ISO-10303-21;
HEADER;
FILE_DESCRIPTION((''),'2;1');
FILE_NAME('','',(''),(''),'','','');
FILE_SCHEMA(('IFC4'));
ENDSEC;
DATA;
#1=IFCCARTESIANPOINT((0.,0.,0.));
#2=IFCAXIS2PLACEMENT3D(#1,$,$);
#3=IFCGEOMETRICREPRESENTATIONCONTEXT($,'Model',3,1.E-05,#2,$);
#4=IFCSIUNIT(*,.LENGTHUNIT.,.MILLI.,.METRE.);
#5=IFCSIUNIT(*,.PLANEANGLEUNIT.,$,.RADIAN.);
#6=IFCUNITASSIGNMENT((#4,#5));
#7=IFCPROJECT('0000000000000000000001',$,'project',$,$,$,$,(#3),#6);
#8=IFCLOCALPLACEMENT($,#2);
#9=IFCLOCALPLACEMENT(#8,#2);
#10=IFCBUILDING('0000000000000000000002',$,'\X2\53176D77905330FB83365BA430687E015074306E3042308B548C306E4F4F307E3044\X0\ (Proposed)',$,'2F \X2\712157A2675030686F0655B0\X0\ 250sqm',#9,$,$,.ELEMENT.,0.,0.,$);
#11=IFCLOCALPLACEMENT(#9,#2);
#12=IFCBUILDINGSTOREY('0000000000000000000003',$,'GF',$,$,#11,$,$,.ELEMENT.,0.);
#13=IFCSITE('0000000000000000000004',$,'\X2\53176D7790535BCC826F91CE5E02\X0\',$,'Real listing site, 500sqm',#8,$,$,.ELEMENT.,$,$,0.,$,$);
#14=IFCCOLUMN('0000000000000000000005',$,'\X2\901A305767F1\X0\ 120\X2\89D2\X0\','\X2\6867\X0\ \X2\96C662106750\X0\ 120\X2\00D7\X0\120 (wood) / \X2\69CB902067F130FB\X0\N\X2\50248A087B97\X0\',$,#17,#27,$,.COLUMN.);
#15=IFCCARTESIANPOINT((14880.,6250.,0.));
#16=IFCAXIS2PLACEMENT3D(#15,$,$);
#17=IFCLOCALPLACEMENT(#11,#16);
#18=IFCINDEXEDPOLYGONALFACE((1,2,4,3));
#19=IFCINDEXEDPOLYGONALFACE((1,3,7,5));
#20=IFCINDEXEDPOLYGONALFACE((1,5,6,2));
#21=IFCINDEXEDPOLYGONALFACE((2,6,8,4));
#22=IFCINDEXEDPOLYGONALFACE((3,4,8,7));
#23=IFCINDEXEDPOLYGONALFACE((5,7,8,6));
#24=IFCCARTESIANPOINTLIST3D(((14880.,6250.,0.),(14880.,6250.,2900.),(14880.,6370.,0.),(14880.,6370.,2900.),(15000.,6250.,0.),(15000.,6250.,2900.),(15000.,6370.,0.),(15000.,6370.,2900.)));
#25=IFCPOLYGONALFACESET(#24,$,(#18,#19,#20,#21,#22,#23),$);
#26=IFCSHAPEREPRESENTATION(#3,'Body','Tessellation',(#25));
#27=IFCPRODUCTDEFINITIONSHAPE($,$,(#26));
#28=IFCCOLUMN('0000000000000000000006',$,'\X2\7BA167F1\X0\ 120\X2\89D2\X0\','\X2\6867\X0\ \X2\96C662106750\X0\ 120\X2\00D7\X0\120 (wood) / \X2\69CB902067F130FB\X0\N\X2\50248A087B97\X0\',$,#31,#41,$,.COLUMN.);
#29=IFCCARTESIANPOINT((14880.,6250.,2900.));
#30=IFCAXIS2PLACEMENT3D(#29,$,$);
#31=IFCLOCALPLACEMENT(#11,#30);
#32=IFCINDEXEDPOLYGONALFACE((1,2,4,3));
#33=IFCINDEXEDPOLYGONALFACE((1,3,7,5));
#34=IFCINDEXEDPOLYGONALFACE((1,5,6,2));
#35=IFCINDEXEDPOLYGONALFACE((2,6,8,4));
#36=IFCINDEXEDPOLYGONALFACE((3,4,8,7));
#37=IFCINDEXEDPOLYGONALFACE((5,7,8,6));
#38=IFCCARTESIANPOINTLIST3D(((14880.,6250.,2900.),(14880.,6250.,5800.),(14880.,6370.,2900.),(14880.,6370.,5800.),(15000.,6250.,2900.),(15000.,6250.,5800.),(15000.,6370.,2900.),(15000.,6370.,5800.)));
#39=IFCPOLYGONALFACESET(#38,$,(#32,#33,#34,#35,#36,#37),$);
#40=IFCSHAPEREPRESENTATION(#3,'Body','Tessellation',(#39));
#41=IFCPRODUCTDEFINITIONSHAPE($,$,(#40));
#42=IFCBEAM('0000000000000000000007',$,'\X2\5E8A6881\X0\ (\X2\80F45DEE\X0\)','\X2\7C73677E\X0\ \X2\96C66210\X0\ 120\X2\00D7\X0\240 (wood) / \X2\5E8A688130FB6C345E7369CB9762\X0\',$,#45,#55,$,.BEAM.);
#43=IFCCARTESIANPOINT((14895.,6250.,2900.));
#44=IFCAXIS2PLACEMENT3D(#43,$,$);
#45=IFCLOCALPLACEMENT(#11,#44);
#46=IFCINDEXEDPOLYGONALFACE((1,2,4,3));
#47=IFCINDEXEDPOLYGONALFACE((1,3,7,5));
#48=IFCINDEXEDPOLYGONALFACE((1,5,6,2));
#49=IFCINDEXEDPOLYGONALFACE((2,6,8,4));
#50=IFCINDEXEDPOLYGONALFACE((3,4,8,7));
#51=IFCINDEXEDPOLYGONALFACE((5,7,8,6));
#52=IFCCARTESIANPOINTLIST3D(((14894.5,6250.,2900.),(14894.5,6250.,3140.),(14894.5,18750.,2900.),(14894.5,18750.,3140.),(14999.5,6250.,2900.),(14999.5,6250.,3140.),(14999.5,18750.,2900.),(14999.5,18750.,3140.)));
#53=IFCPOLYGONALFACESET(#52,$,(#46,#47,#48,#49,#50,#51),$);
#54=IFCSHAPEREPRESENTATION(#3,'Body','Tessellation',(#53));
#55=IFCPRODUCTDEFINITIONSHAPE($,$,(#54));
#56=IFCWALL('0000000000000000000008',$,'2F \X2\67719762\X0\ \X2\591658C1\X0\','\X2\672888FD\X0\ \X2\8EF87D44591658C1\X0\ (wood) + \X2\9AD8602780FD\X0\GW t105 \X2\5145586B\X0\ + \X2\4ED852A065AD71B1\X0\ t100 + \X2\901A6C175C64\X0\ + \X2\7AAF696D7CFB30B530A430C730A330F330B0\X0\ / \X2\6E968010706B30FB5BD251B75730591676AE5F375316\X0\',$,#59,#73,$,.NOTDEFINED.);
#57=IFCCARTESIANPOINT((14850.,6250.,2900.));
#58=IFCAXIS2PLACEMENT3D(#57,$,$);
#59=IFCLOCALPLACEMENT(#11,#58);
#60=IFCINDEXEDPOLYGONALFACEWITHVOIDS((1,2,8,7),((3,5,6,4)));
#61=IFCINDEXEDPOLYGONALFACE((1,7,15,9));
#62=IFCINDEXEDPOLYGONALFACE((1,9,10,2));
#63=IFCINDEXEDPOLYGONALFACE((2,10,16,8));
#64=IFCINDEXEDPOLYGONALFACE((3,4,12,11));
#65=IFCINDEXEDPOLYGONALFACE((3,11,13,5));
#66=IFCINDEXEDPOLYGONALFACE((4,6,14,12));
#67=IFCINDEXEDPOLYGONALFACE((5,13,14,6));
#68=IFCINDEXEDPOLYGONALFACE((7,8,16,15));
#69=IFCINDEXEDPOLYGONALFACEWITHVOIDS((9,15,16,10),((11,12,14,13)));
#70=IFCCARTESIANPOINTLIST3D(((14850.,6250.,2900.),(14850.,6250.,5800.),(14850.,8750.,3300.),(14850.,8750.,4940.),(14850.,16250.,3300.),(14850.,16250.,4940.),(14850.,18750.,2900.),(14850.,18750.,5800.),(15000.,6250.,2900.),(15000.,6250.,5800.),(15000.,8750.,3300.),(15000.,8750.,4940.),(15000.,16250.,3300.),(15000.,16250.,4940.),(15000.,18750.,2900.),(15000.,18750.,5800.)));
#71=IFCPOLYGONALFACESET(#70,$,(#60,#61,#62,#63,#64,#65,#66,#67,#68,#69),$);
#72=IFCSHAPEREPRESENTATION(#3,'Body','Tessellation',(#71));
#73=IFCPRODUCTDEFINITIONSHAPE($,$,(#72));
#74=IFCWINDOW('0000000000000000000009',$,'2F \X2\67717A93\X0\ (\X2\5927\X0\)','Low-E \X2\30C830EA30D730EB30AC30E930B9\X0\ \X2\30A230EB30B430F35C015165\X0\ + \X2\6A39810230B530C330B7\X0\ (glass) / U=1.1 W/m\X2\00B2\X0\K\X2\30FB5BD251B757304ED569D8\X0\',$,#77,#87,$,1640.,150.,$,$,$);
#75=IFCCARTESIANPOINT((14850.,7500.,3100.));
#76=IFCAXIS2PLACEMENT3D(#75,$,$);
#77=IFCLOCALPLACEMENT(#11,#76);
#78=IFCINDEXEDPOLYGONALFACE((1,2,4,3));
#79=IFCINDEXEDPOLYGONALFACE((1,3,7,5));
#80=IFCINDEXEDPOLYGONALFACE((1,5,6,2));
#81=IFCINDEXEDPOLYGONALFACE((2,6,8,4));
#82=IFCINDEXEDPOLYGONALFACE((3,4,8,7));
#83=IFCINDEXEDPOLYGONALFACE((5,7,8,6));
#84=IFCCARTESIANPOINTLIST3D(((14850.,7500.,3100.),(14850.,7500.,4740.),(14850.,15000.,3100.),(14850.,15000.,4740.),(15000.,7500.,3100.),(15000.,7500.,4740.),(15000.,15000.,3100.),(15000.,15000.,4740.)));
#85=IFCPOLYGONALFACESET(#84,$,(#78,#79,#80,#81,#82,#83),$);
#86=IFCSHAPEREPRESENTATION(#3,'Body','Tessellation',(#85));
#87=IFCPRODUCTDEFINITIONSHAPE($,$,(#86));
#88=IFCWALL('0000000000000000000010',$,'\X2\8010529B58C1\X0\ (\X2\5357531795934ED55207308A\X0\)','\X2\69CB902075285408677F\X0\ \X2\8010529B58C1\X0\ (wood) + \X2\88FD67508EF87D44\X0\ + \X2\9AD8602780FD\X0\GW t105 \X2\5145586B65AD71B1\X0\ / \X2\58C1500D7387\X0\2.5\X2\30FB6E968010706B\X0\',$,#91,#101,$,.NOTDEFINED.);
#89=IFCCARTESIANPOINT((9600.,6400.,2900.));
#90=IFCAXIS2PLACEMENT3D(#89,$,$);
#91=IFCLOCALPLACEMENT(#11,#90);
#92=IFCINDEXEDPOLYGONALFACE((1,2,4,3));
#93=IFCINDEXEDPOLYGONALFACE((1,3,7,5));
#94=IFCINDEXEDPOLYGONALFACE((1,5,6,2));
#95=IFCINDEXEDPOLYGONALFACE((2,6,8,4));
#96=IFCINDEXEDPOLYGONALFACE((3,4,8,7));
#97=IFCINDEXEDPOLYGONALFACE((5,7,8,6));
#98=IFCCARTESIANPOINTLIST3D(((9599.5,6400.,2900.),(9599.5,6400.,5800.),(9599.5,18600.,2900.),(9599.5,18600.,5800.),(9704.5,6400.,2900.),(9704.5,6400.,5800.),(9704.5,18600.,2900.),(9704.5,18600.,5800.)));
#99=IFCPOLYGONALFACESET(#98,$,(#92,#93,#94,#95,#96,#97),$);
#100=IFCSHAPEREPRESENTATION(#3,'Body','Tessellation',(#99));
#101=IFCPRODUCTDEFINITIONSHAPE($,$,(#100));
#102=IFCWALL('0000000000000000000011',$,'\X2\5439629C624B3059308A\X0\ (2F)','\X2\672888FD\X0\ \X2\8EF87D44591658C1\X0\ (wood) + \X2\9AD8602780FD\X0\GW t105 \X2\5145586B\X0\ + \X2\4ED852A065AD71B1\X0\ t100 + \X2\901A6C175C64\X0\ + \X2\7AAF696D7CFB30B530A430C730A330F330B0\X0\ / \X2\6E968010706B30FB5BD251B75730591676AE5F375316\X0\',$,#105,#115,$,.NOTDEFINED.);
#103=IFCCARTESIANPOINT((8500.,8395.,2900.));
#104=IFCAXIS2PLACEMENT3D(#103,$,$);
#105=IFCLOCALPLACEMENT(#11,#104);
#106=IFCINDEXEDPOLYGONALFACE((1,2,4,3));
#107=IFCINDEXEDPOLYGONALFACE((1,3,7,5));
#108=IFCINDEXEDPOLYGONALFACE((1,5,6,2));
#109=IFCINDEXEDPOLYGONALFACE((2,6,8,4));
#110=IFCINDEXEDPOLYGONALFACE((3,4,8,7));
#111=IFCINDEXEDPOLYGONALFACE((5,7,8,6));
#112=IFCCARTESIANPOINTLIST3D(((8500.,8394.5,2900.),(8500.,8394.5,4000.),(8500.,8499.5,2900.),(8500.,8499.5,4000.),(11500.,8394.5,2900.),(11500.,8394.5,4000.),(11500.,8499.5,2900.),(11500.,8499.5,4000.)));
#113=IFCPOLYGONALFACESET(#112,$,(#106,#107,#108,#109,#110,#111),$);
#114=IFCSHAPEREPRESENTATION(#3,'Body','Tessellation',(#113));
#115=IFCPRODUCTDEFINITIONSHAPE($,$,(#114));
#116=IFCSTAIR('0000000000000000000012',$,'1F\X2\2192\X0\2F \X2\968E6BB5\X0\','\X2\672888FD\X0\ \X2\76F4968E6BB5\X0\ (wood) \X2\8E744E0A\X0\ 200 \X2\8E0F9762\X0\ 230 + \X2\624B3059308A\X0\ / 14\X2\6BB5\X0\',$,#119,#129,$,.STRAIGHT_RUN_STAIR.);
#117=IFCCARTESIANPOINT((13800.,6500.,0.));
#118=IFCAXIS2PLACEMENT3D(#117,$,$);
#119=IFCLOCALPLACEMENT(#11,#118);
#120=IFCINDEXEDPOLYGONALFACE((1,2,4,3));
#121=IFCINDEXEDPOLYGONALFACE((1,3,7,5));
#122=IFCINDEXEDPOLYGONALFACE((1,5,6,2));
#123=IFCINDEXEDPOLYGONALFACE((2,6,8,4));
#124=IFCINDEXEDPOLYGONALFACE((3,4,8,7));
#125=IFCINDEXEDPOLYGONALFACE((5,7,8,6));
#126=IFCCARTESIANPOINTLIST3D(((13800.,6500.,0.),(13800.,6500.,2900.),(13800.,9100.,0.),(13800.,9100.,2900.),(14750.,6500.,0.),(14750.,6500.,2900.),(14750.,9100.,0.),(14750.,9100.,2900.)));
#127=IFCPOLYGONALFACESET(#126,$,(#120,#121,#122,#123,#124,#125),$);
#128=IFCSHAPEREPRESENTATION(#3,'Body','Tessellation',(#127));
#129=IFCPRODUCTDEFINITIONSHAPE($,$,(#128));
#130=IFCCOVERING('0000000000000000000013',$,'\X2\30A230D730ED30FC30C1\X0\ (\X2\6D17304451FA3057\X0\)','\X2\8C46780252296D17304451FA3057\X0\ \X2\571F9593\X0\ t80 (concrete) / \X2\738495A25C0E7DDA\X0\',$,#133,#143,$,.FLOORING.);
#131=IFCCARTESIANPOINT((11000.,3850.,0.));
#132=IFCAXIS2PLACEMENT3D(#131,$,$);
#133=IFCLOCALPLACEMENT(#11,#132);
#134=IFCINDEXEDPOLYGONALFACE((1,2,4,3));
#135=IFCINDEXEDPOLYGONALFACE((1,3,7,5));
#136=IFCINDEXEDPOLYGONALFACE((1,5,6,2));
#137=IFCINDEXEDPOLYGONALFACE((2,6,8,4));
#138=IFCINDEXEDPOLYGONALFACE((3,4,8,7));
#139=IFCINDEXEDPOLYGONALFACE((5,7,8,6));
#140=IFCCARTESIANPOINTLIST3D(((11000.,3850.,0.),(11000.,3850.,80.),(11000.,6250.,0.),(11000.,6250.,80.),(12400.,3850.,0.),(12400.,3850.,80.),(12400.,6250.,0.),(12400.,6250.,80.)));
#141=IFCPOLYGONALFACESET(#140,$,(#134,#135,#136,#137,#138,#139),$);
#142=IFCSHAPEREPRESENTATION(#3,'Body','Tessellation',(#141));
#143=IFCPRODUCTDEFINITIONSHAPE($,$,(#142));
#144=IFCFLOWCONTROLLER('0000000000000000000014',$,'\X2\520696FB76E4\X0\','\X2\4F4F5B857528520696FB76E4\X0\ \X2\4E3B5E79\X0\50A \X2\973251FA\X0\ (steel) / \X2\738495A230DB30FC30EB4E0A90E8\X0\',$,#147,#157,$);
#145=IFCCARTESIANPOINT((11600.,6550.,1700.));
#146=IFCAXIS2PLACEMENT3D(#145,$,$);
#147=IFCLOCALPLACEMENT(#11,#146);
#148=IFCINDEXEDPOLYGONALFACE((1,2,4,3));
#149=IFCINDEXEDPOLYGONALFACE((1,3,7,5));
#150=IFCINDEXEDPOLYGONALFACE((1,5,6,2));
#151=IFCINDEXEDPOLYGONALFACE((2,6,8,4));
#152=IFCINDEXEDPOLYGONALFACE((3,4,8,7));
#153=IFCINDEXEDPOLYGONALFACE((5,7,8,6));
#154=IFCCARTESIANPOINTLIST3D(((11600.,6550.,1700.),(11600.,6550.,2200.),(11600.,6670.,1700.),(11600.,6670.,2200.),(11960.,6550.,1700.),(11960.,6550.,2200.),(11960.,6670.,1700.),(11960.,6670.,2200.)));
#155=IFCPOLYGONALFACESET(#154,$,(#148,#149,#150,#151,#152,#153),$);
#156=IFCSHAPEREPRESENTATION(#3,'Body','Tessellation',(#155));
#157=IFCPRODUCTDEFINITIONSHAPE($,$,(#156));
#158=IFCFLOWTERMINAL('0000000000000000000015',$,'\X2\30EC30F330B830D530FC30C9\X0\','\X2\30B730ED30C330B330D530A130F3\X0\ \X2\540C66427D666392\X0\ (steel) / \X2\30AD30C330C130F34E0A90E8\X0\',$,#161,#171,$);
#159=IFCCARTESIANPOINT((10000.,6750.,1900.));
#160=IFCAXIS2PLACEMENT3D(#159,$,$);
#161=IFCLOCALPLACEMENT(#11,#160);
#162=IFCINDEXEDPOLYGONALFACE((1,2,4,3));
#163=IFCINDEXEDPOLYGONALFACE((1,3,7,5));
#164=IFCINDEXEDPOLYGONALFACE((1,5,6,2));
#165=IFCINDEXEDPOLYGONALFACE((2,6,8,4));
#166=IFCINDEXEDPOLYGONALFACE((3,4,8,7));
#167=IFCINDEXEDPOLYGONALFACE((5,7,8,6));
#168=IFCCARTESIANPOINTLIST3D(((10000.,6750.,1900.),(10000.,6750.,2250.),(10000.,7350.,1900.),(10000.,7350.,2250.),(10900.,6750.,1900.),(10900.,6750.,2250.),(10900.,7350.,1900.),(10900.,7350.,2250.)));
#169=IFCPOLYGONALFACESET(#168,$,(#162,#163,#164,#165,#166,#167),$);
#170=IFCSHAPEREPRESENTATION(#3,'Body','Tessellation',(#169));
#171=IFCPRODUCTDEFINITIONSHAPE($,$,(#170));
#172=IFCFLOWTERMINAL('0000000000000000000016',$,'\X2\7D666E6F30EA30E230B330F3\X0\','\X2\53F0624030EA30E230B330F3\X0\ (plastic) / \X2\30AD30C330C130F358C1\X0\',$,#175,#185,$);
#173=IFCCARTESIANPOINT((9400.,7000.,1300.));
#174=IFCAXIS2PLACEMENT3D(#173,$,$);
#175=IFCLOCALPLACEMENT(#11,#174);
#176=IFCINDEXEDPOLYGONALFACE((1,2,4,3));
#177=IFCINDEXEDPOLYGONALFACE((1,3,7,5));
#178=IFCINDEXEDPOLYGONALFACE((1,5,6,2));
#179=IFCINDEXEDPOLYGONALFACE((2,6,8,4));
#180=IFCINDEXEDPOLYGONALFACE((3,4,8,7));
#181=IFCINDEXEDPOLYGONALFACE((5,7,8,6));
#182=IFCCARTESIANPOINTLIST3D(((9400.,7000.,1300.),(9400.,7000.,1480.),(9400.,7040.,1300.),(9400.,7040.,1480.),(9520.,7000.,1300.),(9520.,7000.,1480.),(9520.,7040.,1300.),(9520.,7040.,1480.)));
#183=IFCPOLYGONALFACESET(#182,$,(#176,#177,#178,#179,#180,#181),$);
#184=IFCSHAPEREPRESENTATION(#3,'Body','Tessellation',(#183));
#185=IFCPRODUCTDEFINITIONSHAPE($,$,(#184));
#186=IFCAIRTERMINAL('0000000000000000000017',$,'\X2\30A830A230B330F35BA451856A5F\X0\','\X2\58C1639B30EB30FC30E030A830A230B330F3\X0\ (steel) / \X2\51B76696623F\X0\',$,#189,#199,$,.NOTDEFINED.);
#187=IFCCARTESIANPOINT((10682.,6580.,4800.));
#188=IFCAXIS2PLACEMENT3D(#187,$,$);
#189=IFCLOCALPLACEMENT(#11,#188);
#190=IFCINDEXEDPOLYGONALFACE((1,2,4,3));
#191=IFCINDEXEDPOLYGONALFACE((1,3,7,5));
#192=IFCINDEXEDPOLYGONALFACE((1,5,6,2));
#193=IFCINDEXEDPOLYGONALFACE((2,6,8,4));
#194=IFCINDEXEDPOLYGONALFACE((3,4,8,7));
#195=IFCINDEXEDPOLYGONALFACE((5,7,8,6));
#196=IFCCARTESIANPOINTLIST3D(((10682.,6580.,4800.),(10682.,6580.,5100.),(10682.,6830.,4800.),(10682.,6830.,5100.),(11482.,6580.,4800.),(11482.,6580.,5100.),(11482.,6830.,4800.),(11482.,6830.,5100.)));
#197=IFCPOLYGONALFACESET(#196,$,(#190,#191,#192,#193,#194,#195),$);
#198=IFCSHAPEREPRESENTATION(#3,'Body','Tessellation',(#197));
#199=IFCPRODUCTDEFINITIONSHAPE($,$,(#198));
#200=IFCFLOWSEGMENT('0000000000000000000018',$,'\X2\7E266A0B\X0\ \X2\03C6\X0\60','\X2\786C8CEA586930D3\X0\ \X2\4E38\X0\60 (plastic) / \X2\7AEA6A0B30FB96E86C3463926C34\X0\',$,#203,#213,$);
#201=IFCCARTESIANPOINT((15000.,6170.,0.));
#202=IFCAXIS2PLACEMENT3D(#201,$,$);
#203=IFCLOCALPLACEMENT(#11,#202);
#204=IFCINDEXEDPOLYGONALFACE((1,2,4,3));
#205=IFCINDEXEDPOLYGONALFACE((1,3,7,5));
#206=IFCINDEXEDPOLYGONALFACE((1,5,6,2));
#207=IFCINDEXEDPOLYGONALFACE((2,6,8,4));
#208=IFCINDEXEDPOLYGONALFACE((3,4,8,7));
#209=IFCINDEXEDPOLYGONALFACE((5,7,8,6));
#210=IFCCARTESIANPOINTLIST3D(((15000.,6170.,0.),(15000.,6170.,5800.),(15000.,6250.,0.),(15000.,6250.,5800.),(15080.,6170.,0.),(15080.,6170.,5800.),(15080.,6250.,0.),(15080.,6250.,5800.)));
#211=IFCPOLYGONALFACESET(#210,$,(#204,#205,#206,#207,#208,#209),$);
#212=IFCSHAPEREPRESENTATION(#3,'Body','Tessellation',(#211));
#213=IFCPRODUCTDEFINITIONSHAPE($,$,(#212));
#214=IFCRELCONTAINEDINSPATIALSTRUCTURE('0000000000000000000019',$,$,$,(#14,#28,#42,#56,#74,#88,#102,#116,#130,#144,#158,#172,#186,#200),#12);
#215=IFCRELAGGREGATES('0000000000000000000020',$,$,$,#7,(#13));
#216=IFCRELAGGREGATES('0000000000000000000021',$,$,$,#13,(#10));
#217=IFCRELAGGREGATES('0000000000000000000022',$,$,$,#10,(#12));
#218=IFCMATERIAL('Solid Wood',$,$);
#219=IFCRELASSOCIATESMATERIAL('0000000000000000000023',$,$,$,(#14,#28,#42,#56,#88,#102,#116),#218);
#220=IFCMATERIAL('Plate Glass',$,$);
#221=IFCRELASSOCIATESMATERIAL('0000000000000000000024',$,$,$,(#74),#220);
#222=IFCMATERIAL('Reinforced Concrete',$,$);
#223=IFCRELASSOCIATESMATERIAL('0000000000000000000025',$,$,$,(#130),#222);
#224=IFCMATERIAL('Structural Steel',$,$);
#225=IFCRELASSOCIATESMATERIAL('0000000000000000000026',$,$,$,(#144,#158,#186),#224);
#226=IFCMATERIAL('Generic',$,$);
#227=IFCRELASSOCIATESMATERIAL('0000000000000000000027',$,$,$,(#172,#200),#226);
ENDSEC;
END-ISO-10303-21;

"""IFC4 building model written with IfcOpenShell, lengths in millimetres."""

from ifc_helpers import new_model, si_unit, frame, frame_2d, origin, place, context, project, spatial, rectangle, extrude, material, element, fill, save


model = new_model("IFC4")

# Units and contexts
model_context = context("Model", 3, precision=1e-05, world=origin())
ifc_project = project(units=[si_unit("LENGTHUNIT", "METRE", prefix="MILLI"), si_unit("PLANEANGLEUNIT", "RADIAN")], contexts=[model_context])

# Site, building, storey
site_placement = place(None, origin())
site = spatial("IfcSite", under=ifc_project, at=site_placement, Name="北海道富良野市", ObjectType="Real listing site, 500sqm", CompositionType="ELEMENT", RefElevation=0.0)
building_placement = place(site_placement, origin())
building = spatial("IfcBuilding", under=site, at=building_placement, Name="北海道・茶室と縁側のある和の住まい (Proposed)", ObjectType="2F 無垢材と漆喰 250sqm", CompositionType="ELEMENT", ElevationOfRefHeight=0.0, ElevationOfTerrain=0.0)
storey_placement = place(building_placement, origin())
storey = spatial("IfcBuildingStorey", under=building, at=storey_placement, Name="GF", CompositionType="ELEMENT", Elevation=0.0)

# Columns
ifc_material_1 = material(Name="Solid Wood")
column_1_placement = place(storey_placement, frame((14880.0, 6250.0, 0.0)))
element("IfcColumn", 1, at=column_1_placement, inside=storey, material=ifc_material_1, Name="通し柱 120角", Description="桧 集成材 120×120 (wood) / 構造柱・N値計算", PredefinedType="COLUMN", context=model_context, shape_type="SweptSolid", body=[
    extrude(rectangle(XDim=120.0, YDim=120.0, at=frame_2d((60.0, 60.0))), frame((14880.0, 6250.0, 0.0)), (0.0, 0.0, 1.0), 2900.0),
])
column_2_placement = place(storey_placement, frame((14880.0, 6250.0, 2900.0)))
element("IfcColumn", 2, at=column_2_placement, inside=storey, material=ifc_material_1, Name="管柱 120角", Description="桧 集成材 120×120 (wood) / 構造柱・N値計算", PredefinedType="COLUMN", context=model_context, shape_type="SweptSolid", body=[
    extrude(rectangle(XDim=120.0, YDim=120.0, at=frame_2d((60.0, 60.0))), frame((14880.0, 6250.0, 2900.0)), (0.0, 0.0, 1.0), 2900.0),
])

# Beam
beam_1_placement = place(storey_placement, frame((14895.0, 6250.0, 2900.0)))
element("IfcBeam", 3, at=beam_1_placement, inside=storey, material=ifc_material_1, Name="床梁 (胴差)", Description="米松 集成 120×240 (wood) / 床梁・水平構面", PredefinedType="BEAM", context=model_context, shape_type="SweptSolid", body=[
    extrude(rectangle(XDim=105.0, YDim=12500.0, at=frame_2d((52.0, 6250.0))), frame((14895.0, 6250.0, 2900.0)), (0.0, 0.0, 1.0), 240.0),
])

# Shared definitions
ifc_material_2 = material(Name="Plate Glass")

# Wall, opening, window
wall_1_placement = place(storey_placement, frame((14850.0, 6250.0, 2900.0)))
wall_1 = element("IfcWall", 4, at=wall_1_placement, inside=storey, material=ifc_material_1, Name="2F 東面 外壁", Description="木製 軸組外壁 (wood) + 高性能GW t105 充填 + 付加断熱 t100 + 通気層 + 窯業系サイディング / 準耐火・寒冷地外皮強化", PredefinedType="NOTDEFINED", context=model_context, shape_type="SweptSolid", body=[
    extrude(rectangle(XDim=150.0, YDim=12500.0, at=frame_2d((75.0, 6250.0))), frame((14850.0, 6250.0, 2900.0)), (0.0, 0.0, 1.0), 2900.0),
])
opening_1_placement = place(storey_placement, frame((14850.0, 7500.0, 3100.0)))
opening_1 = element("IfcOpeningElement", 5, at=opening_1_placement, cuts=wall_1, PredefinedType="NOTDEFINED", context=model_context, shape_type="SweptSolid", body=[
    extrude(rectangle(XDim=150.0, YDim=7500.0, at=frame_2d((75.0, 3750.0))), frame((14850.0, 7500.0, 3100.0)), (0.0, 0.0, 1.0), 1640.0),
])
window_1_placement = place(storey_placement, frame((14850.0, 7500.0, 3100.0)))
window_1 = element("IfcWindow", 6, at=window_1_placement, inside=storey, material=ifc_material_2, Name="2F 東窓 (大)", Description="Low-E トリプルガラス アルゴン封入 + 樹脂サッシ (glass) / U=1.1 W/m²K・寒冷地仕様", OverallHeight=1640.0, OverallWidth=150.0, context=model_context, shape_type="SweptSolid", body=[
    extrude(rectangle(XDim=150.0, YDim=7500.0, at=frame_2d((75.0, 3750.0))), frame((14850.0, 7500.0, 3100.0)), (0.0, 0.0, 1.0), 1640.0),
])
fill(opening_1, window_1)

# Walls
wall_2_placement = place(storey_placement, frame((9600.0, 6400.0, 2900.0)))
element("IfcWall", 7, at=wall_2_placement, inside=storey, material=ifc_material_1, Name="耐力壁 (南北間仕切り)", Description="構造用合板 耐力壁 (wood) + 製材軸組 + 高性能GW t105 充填断熱 / 壁倍率2.5・準耐火", PredefinedType="NOTDEFINED", context=model_context, shape_type="SweptSolid", body=[
    extrude(rectangle(XDim=105.0, YDim=12200.0, at=frame_2d((52.0, 6100.0))), frame((9600.0, 6400.0, 2900.0)), (0.0, 0.0, 1.0), 2900.0),
])
wall_3_placement = place(storey_placement, frame((8500.0, 8395.0, 2900.0)))
element("IfcWall", 8, at=wall_3_placement, inside=storey, material=ifc_material_1, Name="吹抜手すり (2F)", Description="木製 軸組外壁 (wood) + 高性能GW t105 充填 + 付加断熱 t100 + 通気層 + 窯業系サイディング / 準耐火・寒冷地外皮強化", PredefinedType="NOTDEFINED", context=model_context, shape_type="SweptSolid", body=[
    extrude(rectangle(XDim=3000.0, YDim=105.0, at=frame_2d((1500.0, 52.0))), frame((8500.0, 8395.0, 2900.0)), (0.0, 0.0, 1.0), 1100.0),
])

# Stair
stair_placement = place(storey_placement, frame((13800.0, 6500.0, 0.0)))
element("IfcStair", 9, at=stair_placement, inside=storey, material=ifc_material_1, Name="1F→2F 階段", Description="木製 直階段 (wood) 蹴上 200 踏面 230 + 手すり / 14段", PredefinedType="STRAIGHT_RUN_STAIR", context=model_context, shape_type="SweptSolid", body=[
    extrude(rectangle(XDim=950.0, YDim=2600.0, at=frame_2d((475.0, 1300.0))), frame((13800.0, 6500.0, 0.0)), (0.0, 0.0, 1.0), 2900.0),
])

# Covering
ifc_material_3 = material(Name="Reinforced Concrete")
covering_placement = place(storey_placement, frame((11000.0, 3850.0, 0.0)))
element("IfcCovering", 10, at=covering_placement, inside=storey, material=ifc_material_3, Name="アプローチ (洗い出し)", Description="豆砂利洗い出し 土間 t80 (concrete) / 玄関導線", PredefinedType="FLOORING", context=model_context, shape_type="SweptSolid", body=[
    extrude(rectangle(XDim=1400.0, YDim=2400.0, at=frame_2d((700.0, 1200.0))), frame((11000.0, 3850.0, 0.0)), (0.0, 0.0, 1.0), 80.0),
])

# Flow controller
ifc_material_4 = material(Name="Structural Steel")
flow_controller_placement = place(storey_placement, frame((11600.0, 6550.0, 1700.0)))
element("IfcFlowController", 11, at=flow_controller_placement, inside=storey, material=ifc_material_4, Name="分電盤", Description="住宅用分電盤 主幹50A 露出 (steel) / 玄関ホール上部", context=model_context, shape_type="SweptSolid", body=[
    extrude(rectangle(XDim=360.0, YDim=120.0, at=frame_2d((180.0, 60.0))), frame((11600.0, 6550.0, 1700.0)), (0.0, 0.0, 1.0), 500.0),
])

# Flow terminals
flow_terminal_1_placement = place(storey_placement, frame((10000.0, 6750.0, 1900.0)))
element("IfcFlowTerminal", 12, at=flow_terminal_1_placement, inside=storey, material=ifc_material_4, Name="レンジフード", Description="シロッコファン 同時給排 (steel) / キッチン上部", context=model_context, shape_type="SweptSolid", body=[
    extrude(rectangle(XDim=900.0, YDim=600.0, at=frame_2d((450.0, 300.0))), frame((10000.0, 6750.0, 1900.0)), (0.0, 0.0, 1.0), 350.0),
])
ifc_material_5 = material(Name="Generic")
flow_terminal_2_placement = place(storey_placement, frame((9400.0, 7000.0, 1300.0)))
element("IfcFlowTerminal", 13, at=flow_terminal_2_placement, inside=storey, material=ifc_material_5, Name="給湯リモコン", Description="台所リモコン (plastic) / キッチン壁", context=model_context, shape_type="SweptSolid", body=[
    extrude(rectangle(XDim=120.0, YDim=40.0, at=frame_2d((60.0, 20.0))), frame((9400.0, 7000.0, 1300.0)), (0.0, 0.0, 1.0), 180.0),
])

# Air terminal
air_terminal_placement = place(storey_placement, frame((10682.0, 6580.0, 4800.0)))
element("IfcAirTerminal", 14, at=air_terminal_placement, inside=storey, material=ifc_material_4, Name="エアコン室内機", Description="壁掛ルームエアコン (steel) / 冷暖房", PredefinedType="NOTDEFINED", context=model_context, shape_type="SweptSolid", body=[
    extrude(rectangle(XDim=800.0, YDim=250.0, at=frame_2d((400.0, 125.0))), frame((10682.0, 6580.0, 4800.0)), (0.0, 0.0, 1.0), 300.0),
])

# Flow segment
flow_segment_placement = place(storey_placement, frame((15000.0, 6170.0, 0.0)))
element("IfcFlowSegment", 15, at=flow_segment_placement, inside=storey, material=ifc_material_5, Name="縦樋 φ60", Description="硬質塩ビ 丸60 (plastic) / 竪樋・雨水排水", context=model_context, shape_type="SweptSolid", body=[
    extrude(rectangle(XDim=80.0, YDim=80.0, at=frame_2d((40.0, 40.0))), frame((15000.0, 6170.0, 0.0)), (0.0, 0.0, 1.0), 5800.0),
])

save(model, "model.ifc")
